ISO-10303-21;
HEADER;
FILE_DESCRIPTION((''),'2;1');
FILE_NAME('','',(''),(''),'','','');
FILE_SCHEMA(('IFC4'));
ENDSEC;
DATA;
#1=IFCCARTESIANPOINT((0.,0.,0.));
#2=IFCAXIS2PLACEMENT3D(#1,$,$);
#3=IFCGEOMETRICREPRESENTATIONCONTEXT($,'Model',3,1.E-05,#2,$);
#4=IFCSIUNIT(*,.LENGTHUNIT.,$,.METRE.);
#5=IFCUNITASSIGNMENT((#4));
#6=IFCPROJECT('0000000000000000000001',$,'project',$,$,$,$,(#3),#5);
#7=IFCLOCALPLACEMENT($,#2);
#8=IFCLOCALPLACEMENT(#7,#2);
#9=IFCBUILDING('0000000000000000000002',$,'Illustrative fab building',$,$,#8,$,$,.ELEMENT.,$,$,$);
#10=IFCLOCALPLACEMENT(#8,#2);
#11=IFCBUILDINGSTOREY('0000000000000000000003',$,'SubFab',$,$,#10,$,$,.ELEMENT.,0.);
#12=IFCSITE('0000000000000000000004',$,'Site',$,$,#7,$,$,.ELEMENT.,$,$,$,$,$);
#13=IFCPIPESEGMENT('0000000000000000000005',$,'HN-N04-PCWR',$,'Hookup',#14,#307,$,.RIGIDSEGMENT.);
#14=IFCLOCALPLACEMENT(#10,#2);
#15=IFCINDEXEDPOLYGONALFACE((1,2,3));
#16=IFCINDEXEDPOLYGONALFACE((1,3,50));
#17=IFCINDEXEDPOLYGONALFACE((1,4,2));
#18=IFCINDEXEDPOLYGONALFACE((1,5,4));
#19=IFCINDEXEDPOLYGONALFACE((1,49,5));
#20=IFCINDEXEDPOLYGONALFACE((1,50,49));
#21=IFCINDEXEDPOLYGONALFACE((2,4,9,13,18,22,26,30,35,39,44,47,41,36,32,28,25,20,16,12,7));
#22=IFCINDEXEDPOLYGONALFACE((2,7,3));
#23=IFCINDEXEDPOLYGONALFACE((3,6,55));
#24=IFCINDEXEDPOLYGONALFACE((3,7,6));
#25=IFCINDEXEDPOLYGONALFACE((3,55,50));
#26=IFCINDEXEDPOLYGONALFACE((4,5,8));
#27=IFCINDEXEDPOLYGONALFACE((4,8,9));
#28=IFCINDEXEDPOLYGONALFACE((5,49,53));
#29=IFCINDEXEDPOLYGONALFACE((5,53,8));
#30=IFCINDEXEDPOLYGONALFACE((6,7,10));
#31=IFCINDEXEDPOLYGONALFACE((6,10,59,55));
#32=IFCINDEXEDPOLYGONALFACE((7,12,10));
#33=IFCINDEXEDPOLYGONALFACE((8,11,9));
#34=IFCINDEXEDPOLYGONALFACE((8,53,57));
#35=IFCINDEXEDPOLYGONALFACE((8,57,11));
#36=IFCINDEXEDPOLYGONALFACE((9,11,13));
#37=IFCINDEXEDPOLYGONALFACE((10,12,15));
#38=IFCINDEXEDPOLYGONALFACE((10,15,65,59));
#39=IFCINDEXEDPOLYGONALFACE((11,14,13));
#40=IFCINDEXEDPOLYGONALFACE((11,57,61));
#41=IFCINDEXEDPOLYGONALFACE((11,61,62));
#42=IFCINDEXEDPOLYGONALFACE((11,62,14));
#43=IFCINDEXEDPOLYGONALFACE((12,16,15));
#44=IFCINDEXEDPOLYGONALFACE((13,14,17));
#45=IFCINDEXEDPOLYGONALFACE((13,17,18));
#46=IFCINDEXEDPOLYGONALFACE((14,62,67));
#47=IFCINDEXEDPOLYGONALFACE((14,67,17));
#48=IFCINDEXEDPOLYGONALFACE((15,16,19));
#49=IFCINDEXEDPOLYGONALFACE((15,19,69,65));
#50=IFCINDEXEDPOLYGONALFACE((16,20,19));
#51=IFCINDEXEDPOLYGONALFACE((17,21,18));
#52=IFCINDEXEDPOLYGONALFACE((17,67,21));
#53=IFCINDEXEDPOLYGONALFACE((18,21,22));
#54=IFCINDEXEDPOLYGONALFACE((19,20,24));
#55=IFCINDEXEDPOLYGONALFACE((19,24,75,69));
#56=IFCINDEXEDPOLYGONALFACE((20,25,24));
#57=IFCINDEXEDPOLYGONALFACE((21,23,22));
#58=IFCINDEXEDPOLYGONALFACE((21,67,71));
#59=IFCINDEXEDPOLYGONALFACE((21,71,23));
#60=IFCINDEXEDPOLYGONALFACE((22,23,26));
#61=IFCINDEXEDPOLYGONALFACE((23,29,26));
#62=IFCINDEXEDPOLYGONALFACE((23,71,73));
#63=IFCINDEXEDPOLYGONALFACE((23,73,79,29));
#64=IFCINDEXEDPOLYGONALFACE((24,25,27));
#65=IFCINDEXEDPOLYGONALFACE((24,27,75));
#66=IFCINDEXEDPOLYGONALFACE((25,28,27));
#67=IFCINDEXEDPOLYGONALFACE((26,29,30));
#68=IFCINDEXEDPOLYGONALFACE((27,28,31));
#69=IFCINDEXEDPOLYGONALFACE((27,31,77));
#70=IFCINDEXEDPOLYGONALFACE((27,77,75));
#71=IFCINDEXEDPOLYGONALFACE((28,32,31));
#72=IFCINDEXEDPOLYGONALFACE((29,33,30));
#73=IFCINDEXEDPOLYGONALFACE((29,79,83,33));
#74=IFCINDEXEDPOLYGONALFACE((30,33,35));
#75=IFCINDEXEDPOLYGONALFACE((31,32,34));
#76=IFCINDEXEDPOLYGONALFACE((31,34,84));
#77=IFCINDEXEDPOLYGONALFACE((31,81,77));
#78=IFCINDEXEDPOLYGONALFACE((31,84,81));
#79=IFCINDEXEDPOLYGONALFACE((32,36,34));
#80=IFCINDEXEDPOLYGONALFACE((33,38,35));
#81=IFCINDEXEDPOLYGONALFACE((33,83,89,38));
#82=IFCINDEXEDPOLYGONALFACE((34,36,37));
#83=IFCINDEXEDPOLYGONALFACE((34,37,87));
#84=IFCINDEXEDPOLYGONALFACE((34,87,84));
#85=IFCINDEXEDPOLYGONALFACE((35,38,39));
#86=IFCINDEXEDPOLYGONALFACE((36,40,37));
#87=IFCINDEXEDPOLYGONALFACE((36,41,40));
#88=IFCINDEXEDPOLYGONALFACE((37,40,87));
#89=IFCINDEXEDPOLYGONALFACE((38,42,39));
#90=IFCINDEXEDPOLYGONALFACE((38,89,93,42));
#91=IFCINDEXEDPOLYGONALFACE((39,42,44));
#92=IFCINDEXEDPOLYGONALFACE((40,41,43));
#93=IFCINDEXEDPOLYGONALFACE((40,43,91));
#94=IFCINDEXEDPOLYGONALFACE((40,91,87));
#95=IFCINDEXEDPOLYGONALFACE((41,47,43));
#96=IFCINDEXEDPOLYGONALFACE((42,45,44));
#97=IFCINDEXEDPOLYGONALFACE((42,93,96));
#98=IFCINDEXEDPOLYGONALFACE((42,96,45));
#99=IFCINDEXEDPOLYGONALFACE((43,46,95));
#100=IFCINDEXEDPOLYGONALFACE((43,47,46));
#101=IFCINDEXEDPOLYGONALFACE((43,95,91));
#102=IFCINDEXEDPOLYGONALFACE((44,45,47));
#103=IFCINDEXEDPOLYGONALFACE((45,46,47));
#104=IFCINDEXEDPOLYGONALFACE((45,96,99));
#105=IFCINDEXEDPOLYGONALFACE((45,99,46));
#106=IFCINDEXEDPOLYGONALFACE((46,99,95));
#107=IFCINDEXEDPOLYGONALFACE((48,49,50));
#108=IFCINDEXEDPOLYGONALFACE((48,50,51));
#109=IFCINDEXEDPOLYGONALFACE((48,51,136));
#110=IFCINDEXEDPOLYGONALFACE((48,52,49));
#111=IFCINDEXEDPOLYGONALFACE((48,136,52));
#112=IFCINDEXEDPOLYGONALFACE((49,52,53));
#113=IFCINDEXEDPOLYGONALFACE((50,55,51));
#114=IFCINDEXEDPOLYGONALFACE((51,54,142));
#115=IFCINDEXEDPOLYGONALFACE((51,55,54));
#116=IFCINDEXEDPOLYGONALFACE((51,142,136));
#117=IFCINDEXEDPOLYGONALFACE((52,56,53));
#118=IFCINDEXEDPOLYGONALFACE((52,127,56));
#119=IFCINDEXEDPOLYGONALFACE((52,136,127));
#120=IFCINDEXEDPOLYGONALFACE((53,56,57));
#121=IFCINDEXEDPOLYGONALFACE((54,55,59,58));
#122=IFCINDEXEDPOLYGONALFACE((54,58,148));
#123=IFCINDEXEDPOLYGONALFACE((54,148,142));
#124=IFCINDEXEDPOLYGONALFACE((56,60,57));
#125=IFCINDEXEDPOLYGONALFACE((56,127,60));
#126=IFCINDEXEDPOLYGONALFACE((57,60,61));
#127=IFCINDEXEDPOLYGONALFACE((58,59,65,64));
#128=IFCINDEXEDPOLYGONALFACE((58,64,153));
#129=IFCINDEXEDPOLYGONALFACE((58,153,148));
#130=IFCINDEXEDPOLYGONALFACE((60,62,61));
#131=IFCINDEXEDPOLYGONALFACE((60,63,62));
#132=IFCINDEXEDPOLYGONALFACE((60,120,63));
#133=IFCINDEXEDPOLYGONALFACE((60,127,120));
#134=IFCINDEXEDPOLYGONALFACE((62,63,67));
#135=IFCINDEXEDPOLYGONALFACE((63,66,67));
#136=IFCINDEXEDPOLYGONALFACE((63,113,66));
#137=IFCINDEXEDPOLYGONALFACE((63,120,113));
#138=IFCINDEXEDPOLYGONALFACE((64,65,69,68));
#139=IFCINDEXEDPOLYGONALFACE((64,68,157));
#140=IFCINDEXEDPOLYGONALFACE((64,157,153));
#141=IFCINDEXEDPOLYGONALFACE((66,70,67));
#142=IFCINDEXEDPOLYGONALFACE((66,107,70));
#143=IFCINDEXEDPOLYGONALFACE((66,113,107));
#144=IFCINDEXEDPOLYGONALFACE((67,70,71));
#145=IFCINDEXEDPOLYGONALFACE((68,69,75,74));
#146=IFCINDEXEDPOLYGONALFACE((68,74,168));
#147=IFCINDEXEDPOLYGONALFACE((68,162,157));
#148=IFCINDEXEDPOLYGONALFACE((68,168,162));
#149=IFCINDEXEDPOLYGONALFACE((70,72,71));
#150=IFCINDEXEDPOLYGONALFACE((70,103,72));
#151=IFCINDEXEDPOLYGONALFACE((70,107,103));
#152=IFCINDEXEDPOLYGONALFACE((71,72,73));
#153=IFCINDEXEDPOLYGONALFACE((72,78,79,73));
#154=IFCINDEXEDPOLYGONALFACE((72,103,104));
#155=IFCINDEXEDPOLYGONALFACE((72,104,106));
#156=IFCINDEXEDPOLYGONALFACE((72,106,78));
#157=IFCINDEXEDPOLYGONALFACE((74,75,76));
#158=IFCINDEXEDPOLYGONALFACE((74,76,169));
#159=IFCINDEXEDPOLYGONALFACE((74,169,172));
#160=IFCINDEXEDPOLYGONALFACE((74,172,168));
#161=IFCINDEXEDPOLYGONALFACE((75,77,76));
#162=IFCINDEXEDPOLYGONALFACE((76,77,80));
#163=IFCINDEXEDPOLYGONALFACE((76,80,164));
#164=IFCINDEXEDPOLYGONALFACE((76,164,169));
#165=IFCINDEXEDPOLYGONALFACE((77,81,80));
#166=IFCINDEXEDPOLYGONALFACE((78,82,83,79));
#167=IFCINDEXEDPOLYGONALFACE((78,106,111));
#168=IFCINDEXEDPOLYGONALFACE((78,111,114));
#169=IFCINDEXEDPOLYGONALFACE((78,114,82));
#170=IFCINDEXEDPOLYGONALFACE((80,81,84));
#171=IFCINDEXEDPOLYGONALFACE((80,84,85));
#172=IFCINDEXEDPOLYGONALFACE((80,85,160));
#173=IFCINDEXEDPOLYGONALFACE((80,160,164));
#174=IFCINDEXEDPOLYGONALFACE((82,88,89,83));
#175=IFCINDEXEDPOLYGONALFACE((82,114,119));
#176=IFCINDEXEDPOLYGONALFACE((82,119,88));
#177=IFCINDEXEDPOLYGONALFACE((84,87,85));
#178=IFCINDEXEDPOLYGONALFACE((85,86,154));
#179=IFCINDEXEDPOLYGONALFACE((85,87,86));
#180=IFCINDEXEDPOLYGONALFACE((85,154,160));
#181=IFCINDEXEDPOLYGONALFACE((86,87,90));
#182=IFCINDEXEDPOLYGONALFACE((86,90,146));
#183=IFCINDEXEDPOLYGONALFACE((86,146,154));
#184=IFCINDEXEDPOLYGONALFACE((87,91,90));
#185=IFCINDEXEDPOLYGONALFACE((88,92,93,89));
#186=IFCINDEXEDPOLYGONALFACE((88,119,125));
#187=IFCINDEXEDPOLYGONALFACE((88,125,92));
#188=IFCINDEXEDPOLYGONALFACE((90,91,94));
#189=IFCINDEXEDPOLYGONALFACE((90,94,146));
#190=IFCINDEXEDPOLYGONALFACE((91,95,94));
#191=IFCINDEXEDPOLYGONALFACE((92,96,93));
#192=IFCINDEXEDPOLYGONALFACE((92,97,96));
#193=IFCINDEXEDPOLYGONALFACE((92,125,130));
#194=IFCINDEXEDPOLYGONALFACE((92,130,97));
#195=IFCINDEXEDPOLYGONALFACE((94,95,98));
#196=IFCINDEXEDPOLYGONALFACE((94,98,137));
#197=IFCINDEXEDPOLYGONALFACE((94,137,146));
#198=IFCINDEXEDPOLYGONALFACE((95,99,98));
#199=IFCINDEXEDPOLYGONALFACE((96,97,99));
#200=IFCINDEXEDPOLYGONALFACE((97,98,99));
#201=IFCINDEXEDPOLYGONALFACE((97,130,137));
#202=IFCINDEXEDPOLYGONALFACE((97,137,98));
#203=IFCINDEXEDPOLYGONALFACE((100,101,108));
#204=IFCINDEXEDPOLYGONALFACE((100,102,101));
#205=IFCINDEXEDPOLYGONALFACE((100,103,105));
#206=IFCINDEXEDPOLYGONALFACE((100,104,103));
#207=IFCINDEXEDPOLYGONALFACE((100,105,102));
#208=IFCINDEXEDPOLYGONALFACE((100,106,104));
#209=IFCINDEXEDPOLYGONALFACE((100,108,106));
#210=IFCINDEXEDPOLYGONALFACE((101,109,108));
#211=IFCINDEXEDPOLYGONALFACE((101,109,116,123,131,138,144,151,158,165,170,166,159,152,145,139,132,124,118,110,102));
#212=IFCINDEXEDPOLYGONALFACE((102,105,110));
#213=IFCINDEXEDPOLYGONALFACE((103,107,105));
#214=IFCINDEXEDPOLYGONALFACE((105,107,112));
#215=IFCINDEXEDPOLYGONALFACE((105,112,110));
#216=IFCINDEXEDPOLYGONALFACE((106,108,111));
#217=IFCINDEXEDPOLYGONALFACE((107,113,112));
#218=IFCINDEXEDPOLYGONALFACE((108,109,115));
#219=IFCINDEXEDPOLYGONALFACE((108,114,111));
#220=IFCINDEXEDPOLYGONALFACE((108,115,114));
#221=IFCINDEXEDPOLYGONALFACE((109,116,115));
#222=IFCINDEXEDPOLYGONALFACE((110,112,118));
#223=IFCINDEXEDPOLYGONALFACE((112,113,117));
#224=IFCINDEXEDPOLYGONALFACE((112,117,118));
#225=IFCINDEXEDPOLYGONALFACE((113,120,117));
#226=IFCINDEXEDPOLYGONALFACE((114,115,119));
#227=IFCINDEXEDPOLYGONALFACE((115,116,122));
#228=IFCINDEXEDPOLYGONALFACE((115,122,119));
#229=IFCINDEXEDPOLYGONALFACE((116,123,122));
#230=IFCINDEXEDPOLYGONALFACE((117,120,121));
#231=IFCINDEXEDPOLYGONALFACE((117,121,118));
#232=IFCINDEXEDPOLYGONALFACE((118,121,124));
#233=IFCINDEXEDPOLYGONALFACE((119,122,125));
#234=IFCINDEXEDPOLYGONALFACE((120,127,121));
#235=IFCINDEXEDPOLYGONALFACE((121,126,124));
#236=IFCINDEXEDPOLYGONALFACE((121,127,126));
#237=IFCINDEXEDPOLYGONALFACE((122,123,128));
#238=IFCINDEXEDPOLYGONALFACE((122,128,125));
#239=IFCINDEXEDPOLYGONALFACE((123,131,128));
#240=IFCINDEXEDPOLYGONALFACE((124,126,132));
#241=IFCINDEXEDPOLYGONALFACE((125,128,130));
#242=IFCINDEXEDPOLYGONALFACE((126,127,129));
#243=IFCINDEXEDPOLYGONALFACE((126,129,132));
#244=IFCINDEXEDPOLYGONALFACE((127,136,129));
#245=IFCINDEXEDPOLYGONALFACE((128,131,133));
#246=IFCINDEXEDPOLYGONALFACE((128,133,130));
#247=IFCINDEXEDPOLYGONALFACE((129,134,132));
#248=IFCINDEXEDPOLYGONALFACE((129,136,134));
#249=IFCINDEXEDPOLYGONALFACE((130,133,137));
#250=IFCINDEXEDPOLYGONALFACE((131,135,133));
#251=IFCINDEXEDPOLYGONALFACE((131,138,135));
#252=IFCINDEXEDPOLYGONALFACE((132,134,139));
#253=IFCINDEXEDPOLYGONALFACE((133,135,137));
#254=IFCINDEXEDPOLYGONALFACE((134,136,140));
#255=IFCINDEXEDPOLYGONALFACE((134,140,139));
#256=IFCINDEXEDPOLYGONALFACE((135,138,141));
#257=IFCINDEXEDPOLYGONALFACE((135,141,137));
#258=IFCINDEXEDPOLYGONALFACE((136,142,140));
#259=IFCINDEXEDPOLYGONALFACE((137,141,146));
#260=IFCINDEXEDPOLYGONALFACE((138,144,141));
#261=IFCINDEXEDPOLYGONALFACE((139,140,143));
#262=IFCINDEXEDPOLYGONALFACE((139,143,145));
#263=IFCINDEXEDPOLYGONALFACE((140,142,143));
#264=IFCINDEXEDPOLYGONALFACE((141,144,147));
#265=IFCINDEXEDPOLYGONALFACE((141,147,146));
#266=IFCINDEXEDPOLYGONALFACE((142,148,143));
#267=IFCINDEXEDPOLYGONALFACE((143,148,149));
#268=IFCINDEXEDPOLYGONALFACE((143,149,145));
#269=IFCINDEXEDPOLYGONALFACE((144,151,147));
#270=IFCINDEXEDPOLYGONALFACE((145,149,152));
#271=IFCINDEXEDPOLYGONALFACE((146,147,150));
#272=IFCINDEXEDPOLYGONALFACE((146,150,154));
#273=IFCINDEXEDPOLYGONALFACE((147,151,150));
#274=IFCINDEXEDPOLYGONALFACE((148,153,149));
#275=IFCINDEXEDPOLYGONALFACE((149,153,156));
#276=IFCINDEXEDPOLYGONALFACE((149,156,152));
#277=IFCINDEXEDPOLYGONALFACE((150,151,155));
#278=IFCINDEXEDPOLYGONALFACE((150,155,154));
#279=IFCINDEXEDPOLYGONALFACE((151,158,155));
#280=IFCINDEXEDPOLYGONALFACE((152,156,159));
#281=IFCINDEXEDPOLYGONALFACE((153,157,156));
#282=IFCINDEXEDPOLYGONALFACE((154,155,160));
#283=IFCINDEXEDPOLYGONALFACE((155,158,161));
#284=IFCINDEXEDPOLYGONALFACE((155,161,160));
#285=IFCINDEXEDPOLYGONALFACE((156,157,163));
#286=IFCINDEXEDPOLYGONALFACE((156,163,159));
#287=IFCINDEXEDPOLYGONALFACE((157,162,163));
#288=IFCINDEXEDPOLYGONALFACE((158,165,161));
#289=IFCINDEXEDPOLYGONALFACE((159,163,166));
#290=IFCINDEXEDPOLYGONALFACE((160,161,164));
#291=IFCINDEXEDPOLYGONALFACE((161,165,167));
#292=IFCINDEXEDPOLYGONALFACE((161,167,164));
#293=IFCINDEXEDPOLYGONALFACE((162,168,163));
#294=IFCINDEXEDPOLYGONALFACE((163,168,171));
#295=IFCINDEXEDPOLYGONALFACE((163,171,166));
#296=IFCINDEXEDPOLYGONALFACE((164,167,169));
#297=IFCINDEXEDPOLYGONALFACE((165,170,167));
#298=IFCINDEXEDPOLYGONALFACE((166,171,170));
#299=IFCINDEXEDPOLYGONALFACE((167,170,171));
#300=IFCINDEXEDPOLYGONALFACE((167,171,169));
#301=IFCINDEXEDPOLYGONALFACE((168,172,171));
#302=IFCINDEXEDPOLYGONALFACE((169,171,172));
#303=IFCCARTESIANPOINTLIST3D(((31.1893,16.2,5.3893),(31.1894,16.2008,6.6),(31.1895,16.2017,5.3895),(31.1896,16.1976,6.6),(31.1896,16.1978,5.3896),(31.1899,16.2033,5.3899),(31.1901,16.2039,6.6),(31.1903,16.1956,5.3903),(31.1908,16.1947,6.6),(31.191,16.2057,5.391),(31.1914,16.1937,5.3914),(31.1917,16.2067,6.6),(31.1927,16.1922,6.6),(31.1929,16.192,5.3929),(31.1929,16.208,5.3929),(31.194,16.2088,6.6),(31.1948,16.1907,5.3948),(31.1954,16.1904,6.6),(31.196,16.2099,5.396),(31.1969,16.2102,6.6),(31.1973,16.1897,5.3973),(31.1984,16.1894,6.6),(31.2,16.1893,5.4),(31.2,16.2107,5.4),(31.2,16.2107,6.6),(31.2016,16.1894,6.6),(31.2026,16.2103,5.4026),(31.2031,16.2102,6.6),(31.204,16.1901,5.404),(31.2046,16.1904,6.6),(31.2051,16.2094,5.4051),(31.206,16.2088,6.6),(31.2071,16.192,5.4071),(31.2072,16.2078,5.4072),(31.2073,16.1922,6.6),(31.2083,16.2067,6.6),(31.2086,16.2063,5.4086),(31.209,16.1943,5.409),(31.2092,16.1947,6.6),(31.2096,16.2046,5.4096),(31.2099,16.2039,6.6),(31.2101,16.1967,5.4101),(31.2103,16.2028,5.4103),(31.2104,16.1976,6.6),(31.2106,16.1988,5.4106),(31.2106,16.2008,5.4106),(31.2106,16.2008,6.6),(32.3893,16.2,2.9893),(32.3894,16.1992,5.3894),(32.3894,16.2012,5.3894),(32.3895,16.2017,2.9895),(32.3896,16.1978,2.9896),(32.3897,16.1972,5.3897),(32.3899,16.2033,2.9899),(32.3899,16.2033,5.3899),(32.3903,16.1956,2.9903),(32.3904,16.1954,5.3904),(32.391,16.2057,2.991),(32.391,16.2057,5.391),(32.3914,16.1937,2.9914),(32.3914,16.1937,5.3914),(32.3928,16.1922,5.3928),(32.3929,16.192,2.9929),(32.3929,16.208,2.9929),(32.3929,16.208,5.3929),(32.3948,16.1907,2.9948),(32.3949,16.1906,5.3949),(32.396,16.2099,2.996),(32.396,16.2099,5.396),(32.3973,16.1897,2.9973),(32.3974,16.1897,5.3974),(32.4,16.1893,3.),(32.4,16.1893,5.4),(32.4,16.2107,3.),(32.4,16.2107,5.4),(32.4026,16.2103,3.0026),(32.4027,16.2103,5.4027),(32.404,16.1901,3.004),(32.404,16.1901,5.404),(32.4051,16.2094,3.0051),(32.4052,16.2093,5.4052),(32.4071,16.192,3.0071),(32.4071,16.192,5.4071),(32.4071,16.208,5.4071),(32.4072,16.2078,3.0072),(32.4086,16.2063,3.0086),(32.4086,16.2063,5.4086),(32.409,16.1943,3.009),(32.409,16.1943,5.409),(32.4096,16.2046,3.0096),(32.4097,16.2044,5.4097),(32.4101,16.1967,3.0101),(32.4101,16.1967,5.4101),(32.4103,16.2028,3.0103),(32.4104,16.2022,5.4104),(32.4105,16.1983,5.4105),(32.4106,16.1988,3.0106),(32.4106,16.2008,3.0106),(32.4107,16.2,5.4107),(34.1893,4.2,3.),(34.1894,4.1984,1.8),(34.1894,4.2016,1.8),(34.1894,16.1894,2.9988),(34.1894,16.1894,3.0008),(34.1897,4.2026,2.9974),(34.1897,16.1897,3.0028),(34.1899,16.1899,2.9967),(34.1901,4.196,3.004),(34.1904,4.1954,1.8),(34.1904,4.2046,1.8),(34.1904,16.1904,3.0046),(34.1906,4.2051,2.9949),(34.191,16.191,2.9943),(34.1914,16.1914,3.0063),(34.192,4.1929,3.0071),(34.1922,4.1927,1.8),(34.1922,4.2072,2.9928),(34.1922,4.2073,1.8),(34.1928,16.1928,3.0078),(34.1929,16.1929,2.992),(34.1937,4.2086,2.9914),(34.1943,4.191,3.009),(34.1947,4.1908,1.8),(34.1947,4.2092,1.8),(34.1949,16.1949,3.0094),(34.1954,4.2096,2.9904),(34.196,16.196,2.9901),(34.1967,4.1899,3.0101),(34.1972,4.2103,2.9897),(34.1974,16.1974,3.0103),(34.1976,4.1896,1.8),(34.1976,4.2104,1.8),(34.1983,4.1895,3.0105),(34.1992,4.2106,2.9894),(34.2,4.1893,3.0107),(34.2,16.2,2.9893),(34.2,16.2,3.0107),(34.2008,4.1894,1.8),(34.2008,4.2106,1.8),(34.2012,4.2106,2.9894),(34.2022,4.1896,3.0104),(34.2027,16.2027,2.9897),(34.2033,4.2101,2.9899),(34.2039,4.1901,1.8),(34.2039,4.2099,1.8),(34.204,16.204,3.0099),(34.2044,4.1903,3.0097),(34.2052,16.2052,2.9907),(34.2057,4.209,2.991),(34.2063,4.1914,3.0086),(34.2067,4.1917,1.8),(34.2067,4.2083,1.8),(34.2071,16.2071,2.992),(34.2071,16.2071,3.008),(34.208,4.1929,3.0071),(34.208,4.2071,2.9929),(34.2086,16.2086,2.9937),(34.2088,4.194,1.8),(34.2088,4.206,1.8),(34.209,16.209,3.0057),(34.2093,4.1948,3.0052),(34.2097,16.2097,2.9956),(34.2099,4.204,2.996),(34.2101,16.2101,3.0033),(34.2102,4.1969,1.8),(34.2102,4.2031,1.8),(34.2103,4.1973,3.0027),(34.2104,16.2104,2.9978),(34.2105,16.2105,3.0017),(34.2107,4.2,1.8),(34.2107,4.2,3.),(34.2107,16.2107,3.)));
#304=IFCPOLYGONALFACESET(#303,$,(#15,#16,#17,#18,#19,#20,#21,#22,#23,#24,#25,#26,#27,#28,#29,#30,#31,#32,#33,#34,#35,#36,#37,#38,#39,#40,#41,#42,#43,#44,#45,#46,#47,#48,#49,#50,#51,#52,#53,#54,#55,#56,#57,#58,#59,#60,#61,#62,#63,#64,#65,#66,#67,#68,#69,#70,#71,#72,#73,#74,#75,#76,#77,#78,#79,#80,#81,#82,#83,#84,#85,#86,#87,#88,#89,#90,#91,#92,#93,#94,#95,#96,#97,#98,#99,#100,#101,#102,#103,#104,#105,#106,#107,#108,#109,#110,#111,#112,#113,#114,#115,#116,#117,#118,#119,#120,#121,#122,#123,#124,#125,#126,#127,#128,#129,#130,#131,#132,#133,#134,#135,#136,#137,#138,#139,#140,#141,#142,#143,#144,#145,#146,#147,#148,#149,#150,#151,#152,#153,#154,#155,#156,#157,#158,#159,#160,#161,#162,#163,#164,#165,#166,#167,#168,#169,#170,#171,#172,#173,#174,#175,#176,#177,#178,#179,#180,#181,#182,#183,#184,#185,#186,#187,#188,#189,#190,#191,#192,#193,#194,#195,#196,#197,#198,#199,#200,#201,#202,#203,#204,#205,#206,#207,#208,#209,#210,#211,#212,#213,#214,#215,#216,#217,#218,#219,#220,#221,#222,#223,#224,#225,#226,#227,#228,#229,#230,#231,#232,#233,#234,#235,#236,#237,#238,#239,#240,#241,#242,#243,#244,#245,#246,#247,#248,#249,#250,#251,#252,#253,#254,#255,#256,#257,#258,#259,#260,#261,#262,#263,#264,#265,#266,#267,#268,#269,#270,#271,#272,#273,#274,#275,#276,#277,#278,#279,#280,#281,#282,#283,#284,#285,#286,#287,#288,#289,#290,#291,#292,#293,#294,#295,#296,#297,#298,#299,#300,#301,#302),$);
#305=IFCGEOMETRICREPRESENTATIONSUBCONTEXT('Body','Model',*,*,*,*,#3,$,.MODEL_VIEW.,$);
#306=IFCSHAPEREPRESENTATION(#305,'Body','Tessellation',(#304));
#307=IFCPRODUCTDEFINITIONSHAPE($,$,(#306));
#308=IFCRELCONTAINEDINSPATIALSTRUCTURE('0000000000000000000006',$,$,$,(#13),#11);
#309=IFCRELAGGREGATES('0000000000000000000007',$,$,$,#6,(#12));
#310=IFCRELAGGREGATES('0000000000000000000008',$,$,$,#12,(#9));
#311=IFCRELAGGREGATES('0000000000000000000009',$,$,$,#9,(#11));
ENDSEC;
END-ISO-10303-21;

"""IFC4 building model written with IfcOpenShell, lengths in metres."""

from ifc_helpers import new_model, entity, si_unit, origin, place, context, subcontext, project, spatial, element, save


model = new_model("IFC4")

# Units and contexts
model_context = context("Model", 3, precision=1e-05, world=origin())
body_context = subcontext(model_context, "Body", "Model", "MODEL_VIEW")
ifc_project = project(units=[si_unit("LENGTHUNIT", "METRE")], contexts=[model_context])

# Site, building, storey
site_placement = place(None, origin())
site = spatial("IfcSite", under=ifc_project, at=site_placement, Name="Site", CompositionType="ELEMENT")
building_placement = place(site_placement, origin())
building = spatial("IfcBuilding", under=site, at=building_placement, Name="Illustrative fab building", CompositionType="ELEMENT")
storey_placement = place(building_placement, origin())
storey = spatial("IfcBuildingStorey", under=building, at=storey_placement, Name="SubFab", CompositionType="ELEMENT", Elevation=0.0)

# Pipe segment
pipe_segment_1_placement = place(storey_placement, origin())
element("IfcPipeSegment", 1, at=pipe_segment_1_placement, inside=storey, Name="HN-N04-PCWR", ObjectType="Hookup", PredefinedType="RIGIDSEGMENT", context=body_context, shape_type="AdvancedSweptSolid", body=[
    entity("IfcSweptDiskSolid", entity("IfcPolyline", [entity("IfcCartesianPoint", [34.2, 4.2, 1.8]), entity("IfcCartesianPoint", [34.2, 4.2, 3.0]), entity("IfcCartesianPoint", [34.2, 16.2, 3.0]), entity("IfcCartesianPoint", [32.4, 16.2, 3.0]), entity("IfcCartesianPoint", [32.4, 16.2, 5.4]), entity("IfcCartesianPoint", [31.2, 16.2, 5.4]), entity("IfcCartesianPoint", [31.2, 16.2, 6.6])]), 0.0107),
])

save(model, "model.ifc")
